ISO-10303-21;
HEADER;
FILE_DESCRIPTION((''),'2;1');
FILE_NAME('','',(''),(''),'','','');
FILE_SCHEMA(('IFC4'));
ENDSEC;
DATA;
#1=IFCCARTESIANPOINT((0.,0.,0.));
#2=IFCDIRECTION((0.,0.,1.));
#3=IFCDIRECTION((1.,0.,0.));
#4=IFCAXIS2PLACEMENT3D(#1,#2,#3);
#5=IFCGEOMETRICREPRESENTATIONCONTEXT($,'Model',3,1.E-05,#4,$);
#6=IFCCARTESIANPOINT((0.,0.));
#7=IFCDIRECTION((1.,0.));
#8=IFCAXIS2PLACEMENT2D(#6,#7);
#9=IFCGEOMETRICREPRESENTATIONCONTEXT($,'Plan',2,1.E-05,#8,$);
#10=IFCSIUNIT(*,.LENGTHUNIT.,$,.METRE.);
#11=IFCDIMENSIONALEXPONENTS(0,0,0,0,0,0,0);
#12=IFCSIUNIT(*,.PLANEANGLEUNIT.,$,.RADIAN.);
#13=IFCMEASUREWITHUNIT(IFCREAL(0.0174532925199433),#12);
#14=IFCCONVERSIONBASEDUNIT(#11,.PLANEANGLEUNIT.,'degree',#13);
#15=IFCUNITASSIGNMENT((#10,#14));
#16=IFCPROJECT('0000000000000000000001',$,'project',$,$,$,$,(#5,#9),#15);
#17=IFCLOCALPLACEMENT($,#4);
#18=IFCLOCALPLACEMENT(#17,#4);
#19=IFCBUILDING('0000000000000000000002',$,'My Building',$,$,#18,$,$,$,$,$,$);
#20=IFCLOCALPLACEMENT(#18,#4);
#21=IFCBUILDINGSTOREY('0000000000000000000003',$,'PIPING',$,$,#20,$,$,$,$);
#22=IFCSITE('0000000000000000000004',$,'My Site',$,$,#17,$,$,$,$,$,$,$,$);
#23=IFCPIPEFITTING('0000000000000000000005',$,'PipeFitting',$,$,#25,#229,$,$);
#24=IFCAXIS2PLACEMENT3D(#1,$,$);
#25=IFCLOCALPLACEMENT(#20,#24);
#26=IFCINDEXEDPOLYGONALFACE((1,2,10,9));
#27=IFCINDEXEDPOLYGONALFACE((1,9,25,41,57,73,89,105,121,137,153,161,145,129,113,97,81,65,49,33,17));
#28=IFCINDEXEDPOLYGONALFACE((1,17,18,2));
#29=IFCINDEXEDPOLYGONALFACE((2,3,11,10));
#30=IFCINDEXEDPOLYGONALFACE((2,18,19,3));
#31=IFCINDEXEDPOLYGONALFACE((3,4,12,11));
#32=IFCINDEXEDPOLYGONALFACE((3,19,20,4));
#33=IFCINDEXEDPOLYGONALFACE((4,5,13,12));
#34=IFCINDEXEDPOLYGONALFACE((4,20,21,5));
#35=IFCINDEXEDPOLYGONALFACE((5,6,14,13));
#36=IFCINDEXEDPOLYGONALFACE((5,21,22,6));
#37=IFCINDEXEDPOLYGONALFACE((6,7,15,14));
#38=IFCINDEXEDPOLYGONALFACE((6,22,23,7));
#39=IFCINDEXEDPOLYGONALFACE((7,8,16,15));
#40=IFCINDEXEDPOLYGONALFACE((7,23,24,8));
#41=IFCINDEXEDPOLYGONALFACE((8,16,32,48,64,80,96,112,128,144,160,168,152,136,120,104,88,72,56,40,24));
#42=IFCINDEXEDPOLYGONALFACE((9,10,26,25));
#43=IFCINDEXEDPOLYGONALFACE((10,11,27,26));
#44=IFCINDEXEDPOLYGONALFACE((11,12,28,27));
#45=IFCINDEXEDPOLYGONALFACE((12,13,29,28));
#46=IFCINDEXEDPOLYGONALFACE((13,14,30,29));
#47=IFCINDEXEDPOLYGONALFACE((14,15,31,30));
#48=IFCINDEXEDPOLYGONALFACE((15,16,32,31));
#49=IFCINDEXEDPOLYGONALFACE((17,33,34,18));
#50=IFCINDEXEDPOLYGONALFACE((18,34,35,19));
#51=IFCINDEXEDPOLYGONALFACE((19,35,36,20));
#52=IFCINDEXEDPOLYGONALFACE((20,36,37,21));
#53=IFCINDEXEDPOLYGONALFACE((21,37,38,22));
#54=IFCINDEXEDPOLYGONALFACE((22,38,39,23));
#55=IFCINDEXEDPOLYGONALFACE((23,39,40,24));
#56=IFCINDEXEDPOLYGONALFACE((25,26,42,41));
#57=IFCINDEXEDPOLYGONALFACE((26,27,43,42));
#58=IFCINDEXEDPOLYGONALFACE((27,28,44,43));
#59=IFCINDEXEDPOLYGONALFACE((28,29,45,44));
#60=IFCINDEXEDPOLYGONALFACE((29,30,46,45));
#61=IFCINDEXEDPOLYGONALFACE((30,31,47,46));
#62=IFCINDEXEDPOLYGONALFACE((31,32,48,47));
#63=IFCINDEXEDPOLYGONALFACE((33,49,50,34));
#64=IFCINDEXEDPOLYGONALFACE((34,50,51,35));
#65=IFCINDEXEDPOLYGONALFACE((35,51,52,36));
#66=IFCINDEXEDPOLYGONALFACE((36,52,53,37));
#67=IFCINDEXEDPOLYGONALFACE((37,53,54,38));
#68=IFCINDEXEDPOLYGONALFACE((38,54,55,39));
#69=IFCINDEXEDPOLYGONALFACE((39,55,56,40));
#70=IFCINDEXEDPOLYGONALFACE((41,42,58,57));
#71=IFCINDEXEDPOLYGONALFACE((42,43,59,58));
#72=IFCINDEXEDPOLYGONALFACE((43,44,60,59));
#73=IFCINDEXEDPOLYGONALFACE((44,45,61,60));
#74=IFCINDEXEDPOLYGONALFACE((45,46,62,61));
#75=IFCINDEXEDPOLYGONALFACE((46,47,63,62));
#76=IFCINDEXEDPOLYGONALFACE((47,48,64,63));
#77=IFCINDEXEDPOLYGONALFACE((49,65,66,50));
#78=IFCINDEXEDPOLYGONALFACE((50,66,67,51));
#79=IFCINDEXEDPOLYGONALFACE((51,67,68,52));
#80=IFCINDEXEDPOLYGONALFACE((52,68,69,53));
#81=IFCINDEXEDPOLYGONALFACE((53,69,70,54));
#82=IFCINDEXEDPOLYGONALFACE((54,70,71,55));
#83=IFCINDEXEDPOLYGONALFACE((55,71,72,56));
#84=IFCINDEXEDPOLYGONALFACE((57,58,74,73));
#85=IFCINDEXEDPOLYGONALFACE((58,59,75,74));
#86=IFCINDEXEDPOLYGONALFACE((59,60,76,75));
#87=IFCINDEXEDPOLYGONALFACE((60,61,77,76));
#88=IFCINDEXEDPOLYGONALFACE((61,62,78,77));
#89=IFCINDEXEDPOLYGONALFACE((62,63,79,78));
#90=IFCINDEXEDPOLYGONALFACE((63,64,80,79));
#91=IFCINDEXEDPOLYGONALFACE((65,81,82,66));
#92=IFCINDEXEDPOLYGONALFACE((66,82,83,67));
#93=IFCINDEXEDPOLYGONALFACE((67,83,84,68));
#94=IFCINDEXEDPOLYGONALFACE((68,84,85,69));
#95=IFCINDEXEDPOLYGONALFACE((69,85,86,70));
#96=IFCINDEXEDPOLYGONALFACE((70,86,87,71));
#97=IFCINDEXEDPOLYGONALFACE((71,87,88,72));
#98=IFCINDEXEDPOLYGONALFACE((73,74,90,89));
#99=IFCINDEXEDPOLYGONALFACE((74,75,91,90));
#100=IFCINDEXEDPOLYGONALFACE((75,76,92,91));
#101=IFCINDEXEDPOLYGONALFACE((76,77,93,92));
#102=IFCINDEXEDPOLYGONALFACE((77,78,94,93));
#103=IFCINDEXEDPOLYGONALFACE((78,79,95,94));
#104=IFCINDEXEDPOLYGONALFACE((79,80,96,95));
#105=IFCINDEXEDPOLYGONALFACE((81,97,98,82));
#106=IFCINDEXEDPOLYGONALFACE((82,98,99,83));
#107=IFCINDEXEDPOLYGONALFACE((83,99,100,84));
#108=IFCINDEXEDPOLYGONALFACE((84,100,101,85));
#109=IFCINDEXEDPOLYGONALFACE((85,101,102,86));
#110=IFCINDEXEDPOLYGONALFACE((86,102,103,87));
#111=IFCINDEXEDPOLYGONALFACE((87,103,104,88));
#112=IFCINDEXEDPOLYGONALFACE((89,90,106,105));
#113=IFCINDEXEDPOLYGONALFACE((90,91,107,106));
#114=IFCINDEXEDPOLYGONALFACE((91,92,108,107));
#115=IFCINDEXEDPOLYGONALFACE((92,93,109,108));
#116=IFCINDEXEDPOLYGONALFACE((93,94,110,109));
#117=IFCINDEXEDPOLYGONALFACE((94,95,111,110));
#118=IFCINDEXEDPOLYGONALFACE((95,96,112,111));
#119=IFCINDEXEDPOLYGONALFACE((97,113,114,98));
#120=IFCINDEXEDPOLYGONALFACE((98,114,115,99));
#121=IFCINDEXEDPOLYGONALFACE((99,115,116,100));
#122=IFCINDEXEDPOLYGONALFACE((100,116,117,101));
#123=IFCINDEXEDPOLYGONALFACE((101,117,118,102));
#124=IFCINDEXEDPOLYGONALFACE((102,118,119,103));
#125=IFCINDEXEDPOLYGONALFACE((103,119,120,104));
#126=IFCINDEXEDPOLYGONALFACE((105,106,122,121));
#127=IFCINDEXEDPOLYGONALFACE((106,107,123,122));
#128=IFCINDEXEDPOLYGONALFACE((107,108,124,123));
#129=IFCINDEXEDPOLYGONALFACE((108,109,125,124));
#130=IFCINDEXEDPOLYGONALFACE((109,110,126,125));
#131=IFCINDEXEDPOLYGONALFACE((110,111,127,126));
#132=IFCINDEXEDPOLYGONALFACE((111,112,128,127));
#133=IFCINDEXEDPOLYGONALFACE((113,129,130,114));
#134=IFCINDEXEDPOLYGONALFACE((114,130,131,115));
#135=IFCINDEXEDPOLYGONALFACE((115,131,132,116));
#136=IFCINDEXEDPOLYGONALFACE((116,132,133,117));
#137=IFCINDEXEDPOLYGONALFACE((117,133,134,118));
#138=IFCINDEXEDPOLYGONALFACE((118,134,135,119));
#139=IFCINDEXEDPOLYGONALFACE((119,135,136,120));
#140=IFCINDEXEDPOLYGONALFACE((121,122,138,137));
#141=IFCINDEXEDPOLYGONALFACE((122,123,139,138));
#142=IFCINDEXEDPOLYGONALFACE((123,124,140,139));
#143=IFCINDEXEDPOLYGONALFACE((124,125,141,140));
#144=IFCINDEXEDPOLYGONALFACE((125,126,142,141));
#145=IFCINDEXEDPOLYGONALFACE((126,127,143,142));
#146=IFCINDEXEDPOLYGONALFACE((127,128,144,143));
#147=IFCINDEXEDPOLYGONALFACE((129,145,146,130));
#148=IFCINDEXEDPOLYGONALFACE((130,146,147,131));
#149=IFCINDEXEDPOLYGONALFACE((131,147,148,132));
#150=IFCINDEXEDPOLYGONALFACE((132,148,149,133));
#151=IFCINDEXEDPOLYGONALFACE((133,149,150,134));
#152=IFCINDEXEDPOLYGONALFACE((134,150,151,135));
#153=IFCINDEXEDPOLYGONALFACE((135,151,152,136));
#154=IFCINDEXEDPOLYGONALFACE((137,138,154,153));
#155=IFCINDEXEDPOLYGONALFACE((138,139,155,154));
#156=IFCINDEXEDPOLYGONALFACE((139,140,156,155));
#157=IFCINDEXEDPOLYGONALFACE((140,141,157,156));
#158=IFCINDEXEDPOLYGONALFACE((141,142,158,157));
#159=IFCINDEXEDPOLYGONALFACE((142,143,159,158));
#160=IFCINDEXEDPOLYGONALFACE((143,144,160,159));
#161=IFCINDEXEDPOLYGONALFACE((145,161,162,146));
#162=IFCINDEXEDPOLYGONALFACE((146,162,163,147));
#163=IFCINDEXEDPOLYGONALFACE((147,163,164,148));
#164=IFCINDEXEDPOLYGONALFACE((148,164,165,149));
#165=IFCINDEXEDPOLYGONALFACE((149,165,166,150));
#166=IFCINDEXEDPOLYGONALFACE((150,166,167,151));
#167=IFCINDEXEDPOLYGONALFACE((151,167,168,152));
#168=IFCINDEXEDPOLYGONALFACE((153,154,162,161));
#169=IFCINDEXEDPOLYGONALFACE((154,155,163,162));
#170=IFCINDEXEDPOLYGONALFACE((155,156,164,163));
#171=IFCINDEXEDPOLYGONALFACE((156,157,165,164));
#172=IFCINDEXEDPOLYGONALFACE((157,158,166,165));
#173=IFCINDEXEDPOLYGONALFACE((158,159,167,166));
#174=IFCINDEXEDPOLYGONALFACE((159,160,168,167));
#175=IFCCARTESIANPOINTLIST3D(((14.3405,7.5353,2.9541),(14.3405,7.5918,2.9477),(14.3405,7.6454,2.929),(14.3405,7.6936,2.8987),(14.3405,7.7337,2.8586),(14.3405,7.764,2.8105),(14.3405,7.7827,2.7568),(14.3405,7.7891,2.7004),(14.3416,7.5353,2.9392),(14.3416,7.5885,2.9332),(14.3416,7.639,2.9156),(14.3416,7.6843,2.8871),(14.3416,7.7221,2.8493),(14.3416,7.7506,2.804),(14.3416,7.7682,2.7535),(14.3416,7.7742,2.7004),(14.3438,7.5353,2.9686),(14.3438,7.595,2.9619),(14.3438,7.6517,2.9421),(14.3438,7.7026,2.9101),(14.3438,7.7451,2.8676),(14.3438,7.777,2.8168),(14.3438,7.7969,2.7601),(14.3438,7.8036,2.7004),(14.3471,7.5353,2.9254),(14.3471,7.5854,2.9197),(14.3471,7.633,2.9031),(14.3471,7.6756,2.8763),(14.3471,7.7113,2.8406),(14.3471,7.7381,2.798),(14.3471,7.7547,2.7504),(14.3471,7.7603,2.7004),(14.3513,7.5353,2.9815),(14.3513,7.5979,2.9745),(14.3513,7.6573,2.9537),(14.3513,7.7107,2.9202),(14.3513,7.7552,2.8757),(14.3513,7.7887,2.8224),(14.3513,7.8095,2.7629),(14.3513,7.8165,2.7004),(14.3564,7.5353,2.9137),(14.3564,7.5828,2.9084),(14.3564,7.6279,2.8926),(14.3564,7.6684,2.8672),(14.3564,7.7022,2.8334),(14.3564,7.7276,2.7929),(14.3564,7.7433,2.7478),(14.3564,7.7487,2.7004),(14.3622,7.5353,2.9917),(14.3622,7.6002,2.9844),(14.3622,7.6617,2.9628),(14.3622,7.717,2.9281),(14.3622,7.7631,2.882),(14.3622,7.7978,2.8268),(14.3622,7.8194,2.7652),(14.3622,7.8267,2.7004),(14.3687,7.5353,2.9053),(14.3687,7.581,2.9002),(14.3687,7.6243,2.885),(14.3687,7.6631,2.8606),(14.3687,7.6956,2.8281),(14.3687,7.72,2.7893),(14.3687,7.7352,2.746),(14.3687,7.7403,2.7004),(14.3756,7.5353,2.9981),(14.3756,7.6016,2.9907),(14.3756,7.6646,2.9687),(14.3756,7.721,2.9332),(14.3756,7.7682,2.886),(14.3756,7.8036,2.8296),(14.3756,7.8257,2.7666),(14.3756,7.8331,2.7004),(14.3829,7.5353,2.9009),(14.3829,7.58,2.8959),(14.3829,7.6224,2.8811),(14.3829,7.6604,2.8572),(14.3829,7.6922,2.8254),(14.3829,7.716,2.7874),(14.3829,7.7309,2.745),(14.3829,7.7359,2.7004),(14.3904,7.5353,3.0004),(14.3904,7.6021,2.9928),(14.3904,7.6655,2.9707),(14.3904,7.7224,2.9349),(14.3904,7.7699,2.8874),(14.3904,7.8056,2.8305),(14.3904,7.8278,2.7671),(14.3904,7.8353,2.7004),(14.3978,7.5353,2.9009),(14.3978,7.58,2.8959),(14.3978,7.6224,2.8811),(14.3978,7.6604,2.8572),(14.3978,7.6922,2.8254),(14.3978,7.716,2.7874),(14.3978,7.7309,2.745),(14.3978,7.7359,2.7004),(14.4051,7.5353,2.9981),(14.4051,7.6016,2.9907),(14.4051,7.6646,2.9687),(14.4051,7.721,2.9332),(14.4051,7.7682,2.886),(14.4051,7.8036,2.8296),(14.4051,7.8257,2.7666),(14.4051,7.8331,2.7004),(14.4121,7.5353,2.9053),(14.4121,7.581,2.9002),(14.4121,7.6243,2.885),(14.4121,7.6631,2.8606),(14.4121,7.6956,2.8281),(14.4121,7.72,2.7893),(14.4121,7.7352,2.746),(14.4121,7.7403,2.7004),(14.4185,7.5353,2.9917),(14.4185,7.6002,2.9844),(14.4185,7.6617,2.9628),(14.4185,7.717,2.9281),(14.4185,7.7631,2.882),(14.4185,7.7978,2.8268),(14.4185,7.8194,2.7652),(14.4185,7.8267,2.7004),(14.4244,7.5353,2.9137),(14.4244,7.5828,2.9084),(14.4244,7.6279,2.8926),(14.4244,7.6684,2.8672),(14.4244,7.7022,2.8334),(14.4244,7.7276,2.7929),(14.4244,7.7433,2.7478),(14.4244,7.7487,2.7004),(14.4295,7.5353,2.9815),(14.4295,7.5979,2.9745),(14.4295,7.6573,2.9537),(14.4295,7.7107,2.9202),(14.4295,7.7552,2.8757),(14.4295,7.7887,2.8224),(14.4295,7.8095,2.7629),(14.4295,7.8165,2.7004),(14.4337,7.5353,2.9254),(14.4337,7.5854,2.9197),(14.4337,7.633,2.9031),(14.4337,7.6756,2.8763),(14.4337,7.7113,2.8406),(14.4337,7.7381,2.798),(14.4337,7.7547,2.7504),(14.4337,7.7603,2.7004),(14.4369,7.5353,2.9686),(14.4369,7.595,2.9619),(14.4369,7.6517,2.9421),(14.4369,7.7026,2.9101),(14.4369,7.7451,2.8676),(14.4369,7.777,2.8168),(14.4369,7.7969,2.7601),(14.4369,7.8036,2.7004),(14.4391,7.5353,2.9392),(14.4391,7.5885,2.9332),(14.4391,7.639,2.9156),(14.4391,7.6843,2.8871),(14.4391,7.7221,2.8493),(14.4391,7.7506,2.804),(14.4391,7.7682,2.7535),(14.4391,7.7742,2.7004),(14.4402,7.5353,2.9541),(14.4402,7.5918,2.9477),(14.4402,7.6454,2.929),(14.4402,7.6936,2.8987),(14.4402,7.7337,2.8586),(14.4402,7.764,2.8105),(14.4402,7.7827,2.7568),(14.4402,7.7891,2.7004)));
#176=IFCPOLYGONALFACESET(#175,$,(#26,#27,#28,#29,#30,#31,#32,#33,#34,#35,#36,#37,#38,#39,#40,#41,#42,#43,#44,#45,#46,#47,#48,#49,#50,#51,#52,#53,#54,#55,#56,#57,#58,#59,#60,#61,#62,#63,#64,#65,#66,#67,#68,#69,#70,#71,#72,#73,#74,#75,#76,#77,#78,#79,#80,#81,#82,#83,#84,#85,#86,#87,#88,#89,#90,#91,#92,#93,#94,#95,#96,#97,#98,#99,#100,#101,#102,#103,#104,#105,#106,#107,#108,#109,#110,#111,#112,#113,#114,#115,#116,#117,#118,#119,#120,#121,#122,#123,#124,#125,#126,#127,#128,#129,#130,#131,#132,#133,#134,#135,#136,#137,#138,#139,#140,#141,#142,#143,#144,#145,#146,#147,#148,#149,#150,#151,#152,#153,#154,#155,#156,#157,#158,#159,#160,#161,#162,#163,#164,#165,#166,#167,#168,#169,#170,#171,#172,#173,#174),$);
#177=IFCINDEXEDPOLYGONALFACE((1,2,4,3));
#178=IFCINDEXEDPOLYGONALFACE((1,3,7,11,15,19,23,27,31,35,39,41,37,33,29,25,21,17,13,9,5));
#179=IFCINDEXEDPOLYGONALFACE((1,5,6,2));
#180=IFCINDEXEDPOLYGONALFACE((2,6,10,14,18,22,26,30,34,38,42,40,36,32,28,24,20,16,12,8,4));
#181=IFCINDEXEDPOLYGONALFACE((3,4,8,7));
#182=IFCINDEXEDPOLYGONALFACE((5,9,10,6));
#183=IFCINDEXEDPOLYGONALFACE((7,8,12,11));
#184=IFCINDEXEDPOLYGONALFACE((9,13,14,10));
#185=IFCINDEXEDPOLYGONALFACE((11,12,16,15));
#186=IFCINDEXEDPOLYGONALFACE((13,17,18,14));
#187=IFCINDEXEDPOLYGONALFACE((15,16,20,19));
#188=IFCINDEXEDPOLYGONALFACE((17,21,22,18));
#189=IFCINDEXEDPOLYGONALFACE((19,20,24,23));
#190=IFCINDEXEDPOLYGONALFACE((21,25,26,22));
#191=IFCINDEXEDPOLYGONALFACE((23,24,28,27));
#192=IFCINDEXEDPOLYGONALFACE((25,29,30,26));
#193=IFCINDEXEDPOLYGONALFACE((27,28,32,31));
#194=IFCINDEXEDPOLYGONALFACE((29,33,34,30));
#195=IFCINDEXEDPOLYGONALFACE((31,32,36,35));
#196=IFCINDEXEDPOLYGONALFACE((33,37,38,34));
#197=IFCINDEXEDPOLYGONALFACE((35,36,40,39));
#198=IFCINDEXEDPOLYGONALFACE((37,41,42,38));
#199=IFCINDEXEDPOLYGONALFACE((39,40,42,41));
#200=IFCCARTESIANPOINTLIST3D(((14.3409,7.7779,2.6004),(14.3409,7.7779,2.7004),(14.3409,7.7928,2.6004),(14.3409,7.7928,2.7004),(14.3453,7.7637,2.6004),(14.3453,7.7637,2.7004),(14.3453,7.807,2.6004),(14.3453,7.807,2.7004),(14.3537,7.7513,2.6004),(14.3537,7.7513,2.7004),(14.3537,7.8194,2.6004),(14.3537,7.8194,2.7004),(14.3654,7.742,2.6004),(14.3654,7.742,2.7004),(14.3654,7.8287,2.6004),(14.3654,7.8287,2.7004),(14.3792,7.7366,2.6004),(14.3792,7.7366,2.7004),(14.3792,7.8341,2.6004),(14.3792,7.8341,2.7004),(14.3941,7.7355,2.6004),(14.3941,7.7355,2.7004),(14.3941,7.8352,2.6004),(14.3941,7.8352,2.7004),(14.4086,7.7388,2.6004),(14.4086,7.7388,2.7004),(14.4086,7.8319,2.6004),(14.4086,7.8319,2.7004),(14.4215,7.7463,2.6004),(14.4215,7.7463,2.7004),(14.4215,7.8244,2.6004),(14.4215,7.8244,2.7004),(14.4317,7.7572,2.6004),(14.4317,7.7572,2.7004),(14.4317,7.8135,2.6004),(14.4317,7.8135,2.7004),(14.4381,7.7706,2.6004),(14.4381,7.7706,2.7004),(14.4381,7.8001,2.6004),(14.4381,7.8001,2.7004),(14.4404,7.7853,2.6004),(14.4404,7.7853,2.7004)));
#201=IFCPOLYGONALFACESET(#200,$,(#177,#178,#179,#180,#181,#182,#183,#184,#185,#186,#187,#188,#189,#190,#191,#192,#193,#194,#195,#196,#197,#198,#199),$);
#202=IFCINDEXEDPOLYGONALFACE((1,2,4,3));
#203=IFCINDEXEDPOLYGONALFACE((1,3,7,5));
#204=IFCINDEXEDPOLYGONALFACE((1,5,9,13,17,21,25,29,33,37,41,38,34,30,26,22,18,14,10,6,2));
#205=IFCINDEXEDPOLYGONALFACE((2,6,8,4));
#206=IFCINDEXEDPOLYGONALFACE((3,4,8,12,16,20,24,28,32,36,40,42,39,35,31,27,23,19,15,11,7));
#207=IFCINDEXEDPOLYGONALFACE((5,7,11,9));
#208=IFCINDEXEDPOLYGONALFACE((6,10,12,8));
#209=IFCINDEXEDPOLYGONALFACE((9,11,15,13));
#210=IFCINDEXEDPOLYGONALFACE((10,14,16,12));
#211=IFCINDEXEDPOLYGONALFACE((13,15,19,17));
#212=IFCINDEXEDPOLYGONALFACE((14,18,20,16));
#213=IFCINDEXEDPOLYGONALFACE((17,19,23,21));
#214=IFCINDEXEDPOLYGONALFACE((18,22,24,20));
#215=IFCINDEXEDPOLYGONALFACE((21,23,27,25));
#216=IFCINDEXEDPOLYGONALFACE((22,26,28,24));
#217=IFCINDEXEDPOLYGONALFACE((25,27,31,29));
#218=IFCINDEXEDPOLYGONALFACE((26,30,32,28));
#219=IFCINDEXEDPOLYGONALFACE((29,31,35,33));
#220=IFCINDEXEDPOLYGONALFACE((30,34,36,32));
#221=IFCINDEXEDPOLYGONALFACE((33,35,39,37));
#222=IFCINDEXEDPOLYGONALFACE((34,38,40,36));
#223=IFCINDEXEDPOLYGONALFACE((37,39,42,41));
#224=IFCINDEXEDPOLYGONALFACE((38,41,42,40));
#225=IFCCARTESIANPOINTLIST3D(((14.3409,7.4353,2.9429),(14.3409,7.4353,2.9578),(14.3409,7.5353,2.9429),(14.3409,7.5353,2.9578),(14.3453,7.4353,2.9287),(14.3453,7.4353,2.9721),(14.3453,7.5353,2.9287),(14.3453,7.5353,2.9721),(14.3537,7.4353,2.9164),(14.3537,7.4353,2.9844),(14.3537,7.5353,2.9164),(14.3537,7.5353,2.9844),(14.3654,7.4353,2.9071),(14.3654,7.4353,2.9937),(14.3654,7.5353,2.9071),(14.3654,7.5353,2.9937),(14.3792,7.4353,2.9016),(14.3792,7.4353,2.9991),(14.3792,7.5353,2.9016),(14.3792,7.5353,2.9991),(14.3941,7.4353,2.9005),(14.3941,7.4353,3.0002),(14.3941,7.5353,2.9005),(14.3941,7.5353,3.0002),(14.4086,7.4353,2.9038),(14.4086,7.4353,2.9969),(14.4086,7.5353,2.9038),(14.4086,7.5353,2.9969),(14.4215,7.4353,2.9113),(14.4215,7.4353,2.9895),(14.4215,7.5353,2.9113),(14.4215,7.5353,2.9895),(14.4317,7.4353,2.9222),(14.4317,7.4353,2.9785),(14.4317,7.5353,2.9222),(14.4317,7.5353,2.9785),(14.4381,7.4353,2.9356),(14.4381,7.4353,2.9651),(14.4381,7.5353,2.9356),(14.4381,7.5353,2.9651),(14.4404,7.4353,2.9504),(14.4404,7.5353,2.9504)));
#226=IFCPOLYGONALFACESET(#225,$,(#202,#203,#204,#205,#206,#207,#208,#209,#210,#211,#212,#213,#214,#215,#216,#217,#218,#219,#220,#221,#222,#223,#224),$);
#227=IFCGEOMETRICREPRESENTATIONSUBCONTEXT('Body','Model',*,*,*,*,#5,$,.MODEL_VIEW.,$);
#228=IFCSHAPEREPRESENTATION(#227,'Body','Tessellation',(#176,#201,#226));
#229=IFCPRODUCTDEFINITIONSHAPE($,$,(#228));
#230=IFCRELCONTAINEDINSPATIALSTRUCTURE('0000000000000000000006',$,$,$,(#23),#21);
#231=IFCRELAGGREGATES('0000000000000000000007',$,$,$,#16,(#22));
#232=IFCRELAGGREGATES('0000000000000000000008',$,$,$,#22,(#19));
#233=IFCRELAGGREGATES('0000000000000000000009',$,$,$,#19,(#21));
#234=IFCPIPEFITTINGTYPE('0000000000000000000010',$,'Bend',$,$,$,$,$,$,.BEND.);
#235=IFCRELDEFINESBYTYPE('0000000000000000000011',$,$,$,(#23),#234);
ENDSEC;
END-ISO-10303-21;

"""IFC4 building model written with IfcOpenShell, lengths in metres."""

from ifc_helpers import new_model, entity, si_unit, converted_unit, frame, origin_with_axes, origin_2d_with_axis, place, context, subcontext, project, spatial, circle, extrude, source, transform, mapped, type_object, type_shapes, element, save


model = new_model("IFC4")

# Units and contexts
model_context = context("Model", 3, precision=1e-05, world=origin_with_axes())
plan_context = context("Plan", 2, precision=1e-05, world=origin_2d_with_axis())
body_context = subcontext(model_context, "Body", "Model", "MODEL_VIEW")
ifc_project = project(units=[si_unit("LENGTHUNIT", "METRE"), converted_unit("PLANEANGLEUNIT", "degree", entity("IfcReal", 0.0174532925199433), si_unit("PLANEANGLEUNIT", "RADIAN"), dimensions=[0, 0, 0, 0, 0, 0, 0])], contexts=[model_context, plan_context])

# Site, building, storey
site_placement = place(None, origin_with_axes())
site = spatial("IfcSite", under=ifc_project, at=site_placement, Name="My Site")
building_placement = place(site_placement, origin_with_axes())
building = spatial("IfcBuilding", under=site, at=building_placement, Name="My Building")
storey_placement = place(building_placement, origin_with_axes())
storey = spatial("IfcBuildingStorey", under=building, at=storey_placement, Name="PIPING")

# Pipe fitting
pipe_fitting_type_1 = type_object("IfcPipeFittingType", Name="Bend", PredefinedType="BEND")
shared_shape = source(origin_with_axes(), body_context, "Body", "SolidModel", [
    entity("IfcSweptDiskSolid", entity("IfcIndexedPolyCurve", entity("IfcCartesianPointList3D", [[0.0, 0.0, -0.1], [0.0, 0.0732, -0.2768], [0.0, 0.25, -0.35]]), [entity("IfcArcIndex", [1, 2, 3])]), 0.05),
    extrude(circle(Radius=0.05), origin_with_axes(), (0.0, 0.0, -1.0), 0.1),
    extrude(circle(Radius=0.05), frame((0.0, 0.25, -0.35), z_axis=(0.0, 1.0, 0.0), x_axis=(1.0, 0.0, 0.0)), (0.0, 0.0, 1.0), 0.1),
])
type_shapes(pipe_fitting_type_1, [shared_shape])
for number, where, z_axis, x_axis, name in (
    (1, (14.3904, 7.7853, 2.6004), (0.0, 0.0, -1.0), (1.0, 0.0, 0.0), "PipeFitting"),
):
    element("IfcPipeFitting", number, at=place(storey_placement, frame(where, z_axis=z_axis, x_axis=x_axis)), inside=storey, type_object=pipe_fitting_type_1, Name=name, context=body_context, shape_type="MappedRepresentation", body=[
        mapped(shared_shape, transform((0.0, 0.0, 0.0), x_axis=(1.0, 0.0, 0.0), y_axis=(0.0, 1.0, 0.0), z_axis=(0.0, 0.0, 1.0), scale=1.0)),
    ])

save(model, "model.ifc")
